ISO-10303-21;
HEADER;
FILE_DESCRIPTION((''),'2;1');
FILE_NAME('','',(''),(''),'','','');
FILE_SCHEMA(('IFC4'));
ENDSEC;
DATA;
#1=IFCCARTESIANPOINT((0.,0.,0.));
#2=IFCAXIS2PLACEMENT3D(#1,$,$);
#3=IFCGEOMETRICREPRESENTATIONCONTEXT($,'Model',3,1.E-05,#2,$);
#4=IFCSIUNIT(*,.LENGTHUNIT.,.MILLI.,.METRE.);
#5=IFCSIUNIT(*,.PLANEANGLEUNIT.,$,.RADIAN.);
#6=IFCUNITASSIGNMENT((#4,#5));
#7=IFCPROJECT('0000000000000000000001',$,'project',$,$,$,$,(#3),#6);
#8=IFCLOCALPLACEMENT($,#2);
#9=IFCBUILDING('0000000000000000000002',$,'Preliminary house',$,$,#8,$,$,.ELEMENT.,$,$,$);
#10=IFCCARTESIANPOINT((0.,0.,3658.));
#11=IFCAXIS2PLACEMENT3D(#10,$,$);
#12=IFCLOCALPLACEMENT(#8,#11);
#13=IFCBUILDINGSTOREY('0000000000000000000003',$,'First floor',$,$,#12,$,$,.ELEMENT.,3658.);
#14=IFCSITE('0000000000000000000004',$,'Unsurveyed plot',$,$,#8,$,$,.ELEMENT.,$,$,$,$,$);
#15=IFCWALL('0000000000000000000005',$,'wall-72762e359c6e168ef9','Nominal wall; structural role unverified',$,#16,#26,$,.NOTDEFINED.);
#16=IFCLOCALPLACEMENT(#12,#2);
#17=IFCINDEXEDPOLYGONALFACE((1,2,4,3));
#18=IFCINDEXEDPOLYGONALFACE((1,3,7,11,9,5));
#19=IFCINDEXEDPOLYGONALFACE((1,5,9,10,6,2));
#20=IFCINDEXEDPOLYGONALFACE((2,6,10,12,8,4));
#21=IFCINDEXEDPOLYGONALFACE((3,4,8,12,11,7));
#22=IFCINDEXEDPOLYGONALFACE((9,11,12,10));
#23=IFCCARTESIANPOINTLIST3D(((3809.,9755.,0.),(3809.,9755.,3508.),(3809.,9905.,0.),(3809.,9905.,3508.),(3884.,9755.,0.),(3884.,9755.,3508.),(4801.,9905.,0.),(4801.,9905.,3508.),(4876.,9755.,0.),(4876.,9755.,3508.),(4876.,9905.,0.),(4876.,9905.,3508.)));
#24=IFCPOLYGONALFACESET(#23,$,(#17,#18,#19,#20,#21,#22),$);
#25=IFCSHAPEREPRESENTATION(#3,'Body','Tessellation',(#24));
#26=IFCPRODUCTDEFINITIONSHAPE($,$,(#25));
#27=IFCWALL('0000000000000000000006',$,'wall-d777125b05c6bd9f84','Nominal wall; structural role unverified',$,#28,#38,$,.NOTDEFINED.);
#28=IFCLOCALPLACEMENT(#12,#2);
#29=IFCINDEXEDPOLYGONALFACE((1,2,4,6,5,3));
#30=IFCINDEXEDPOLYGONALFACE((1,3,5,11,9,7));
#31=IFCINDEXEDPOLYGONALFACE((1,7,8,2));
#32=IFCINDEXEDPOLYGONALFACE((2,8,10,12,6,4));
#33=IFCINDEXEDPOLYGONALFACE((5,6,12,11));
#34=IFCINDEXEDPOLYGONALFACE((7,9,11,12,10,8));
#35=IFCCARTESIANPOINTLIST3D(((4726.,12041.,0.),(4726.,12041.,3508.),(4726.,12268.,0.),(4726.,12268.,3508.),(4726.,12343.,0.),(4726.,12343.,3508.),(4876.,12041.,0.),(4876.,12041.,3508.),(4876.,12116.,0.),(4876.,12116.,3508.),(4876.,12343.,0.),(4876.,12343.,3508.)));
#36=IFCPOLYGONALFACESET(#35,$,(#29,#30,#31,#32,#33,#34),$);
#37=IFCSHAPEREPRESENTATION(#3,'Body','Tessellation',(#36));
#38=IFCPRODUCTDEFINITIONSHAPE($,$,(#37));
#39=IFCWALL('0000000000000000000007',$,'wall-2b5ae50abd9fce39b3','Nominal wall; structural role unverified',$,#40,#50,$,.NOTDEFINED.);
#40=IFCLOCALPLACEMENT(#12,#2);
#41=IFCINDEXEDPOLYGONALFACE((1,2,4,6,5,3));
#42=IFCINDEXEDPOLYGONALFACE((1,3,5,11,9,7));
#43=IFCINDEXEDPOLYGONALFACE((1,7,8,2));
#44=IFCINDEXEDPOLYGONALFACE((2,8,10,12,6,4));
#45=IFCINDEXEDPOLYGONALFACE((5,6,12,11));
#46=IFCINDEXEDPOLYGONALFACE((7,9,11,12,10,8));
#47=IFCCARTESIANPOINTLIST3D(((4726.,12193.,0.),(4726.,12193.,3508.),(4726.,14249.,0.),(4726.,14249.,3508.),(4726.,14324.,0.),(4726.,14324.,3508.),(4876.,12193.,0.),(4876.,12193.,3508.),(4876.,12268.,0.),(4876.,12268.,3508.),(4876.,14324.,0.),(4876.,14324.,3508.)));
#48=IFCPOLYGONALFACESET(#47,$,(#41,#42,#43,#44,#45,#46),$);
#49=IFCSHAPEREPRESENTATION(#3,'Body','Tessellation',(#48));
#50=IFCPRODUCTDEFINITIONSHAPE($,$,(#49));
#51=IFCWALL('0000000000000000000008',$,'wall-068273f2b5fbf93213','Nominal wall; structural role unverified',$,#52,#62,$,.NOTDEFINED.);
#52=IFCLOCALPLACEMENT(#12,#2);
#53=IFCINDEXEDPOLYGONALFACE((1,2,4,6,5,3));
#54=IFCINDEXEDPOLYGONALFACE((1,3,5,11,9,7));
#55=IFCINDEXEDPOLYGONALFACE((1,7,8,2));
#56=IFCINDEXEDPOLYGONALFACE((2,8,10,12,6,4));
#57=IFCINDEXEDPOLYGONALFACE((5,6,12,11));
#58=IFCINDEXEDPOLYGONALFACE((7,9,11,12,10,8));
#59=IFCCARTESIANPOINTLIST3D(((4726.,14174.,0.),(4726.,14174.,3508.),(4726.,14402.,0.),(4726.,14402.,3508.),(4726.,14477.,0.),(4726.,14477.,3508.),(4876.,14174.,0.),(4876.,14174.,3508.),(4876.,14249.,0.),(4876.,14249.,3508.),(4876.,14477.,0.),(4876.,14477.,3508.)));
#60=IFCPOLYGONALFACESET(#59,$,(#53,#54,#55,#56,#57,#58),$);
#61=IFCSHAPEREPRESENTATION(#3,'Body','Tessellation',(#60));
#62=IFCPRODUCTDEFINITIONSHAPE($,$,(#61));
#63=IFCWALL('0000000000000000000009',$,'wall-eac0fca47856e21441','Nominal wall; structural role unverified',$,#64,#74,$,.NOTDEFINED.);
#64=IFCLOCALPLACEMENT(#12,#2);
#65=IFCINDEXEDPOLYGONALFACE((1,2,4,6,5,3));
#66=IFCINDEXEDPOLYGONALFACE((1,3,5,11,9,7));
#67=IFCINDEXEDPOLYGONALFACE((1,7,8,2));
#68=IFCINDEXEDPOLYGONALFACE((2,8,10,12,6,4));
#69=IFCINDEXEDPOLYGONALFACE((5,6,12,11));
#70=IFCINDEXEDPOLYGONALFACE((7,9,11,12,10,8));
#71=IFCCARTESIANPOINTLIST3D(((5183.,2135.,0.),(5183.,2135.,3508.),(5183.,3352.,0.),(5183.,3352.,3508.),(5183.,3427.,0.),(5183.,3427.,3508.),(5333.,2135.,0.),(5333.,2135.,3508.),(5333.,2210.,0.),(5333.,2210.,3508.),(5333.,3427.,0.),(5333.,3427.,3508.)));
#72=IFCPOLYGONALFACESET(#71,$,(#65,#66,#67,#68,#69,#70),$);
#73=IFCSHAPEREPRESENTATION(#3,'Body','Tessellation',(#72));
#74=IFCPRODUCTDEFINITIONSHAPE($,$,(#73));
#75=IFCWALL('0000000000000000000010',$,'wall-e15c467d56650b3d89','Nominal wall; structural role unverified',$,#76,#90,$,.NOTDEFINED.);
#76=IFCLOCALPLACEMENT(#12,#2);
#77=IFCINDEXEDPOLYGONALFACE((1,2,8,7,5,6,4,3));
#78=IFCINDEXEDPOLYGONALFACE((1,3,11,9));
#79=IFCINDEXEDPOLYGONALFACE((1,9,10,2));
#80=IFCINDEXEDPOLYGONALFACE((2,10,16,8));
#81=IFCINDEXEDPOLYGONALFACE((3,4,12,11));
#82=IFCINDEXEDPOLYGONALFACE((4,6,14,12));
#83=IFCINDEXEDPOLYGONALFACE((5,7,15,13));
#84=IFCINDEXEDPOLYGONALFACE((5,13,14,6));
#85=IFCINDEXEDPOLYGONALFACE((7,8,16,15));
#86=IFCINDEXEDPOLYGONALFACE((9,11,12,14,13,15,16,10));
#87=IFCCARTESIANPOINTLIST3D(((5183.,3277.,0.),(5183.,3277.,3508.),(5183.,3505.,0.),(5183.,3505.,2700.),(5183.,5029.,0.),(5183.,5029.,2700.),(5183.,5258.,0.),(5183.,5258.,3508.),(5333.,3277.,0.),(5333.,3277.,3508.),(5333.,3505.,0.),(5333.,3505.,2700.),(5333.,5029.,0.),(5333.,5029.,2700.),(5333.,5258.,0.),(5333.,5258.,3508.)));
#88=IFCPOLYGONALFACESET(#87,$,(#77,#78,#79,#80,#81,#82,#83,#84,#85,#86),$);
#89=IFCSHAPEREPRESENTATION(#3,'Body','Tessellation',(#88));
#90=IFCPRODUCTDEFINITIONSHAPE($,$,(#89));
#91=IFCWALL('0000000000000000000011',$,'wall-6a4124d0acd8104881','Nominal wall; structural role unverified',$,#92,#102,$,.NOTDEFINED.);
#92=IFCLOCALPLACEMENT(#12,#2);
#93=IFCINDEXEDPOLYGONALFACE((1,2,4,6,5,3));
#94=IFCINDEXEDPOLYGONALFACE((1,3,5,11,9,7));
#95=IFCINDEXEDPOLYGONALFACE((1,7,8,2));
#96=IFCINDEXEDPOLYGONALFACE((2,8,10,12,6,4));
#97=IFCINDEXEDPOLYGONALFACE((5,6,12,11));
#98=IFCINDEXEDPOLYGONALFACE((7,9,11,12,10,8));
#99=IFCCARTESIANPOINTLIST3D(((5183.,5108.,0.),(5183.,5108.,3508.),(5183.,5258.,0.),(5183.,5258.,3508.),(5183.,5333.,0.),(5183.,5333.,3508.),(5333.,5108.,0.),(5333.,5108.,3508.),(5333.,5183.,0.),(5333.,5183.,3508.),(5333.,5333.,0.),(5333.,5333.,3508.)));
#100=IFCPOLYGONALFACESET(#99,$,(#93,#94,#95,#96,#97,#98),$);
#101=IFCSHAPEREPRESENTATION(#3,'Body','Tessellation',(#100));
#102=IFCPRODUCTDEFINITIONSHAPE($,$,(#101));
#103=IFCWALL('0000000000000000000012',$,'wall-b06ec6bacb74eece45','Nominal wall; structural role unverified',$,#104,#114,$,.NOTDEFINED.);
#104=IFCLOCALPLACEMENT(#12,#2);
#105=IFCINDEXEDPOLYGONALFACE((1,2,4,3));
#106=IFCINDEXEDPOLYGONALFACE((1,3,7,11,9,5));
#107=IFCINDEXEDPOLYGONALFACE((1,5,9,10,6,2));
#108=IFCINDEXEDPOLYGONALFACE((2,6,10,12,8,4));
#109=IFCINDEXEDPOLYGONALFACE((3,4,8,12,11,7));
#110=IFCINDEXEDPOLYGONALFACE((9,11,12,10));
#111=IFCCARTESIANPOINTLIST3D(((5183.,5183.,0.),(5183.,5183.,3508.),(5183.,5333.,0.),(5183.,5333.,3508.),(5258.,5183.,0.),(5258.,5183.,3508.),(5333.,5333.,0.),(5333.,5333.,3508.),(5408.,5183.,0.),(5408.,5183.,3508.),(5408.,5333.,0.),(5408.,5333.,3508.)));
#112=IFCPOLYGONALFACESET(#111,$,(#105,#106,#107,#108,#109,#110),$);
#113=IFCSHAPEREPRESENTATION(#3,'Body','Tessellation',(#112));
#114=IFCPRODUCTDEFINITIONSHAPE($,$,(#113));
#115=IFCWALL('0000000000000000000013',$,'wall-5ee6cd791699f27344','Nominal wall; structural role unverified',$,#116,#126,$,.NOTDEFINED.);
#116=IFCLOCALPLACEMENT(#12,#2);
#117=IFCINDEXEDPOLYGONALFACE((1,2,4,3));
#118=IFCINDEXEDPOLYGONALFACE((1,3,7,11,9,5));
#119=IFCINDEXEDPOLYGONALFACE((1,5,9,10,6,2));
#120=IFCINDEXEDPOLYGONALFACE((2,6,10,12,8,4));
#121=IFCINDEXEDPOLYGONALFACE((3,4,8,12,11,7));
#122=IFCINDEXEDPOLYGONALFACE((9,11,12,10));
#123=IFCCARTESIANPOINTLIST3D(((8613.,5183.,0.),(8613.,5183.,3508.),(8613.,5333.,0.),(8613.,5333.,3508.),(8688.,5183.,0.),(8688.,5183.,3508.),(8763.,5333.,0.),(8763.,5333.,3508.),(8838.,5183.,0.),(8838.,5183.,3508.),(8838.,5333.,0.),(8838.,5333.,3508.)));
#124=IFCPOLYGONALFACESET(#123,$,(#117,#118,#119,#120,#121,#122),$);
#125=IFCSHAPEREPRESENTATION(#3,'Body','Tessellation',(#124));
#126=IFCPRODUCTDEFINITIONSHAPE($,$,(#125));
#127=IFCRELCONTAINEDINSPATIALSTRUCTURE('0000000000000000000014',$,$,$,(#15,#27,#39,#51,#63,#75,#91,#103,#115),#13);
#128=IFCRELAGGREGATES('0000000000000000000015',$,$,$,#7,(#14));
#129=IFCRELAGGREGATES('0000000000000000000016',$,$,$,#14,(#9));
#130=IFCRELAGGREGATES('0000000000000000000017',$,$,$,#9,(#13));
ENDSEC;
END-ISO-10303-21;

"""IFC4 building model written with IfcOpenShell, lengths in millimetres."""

from ifc_helpers import new_model, si_unit, frame, origin, place, context, project, spatial, polyline, outline, extrude, element, save


model = new_model("IFC4")

# Units and contexts
model_context = context("Model", 3, precision=1e-05, world=origin())
ifc_project = project(units=[si_unit("LENGTHUNIT", "METRE", prefix="MILLI"), si_unit("PLANEANGLEUNIT", "RADIAN")], contexts=[model_context])

# Site, building, storey
placement_1 = place(None, origin())
site = spatial("IfcSite", under=ifc_project, at=placement_1, Name="Unsurveyed plot", CompositionType="ELEMENT")
building = spatial("IfcBuilding", under=site, at=placement_1, Name="Preliminary house", CompositionType="ELEMENT")
placement_2 = place(placement_1, frame((0.0, 0.0, 3658.0)))
storey = spatial("IfcBuildingStorey", under=building, at=placement_2, Name="First floor", CompositionType="ELEMENT", Elevation=3658.0)

# Wall
element("IfcWall", 1, at=placement_2, inside=storey, Name="wall-72762e359c6e168ef9", Description="Nominal wall; structural role unverified", PredefinedType="NOTDEFINED", context=model_context, shape_type="SweptSolid", body=[
    extrude(outline(polyline([(4801.0, 9905.0), (4876.0, 9905.0), (4876.0, 9755.0), (3884.0, 9755.0), (3809.0, 9755.0), (3809.0, 9905.0), (4801.0, 9905.0)])), origin(), (0.0, 0.0, 1.0), 3508.0),
])

# Walls
element("IfcWall", 2, at=placement_2, inside=storey, Name="wall-d777125b05c6bd9f84", Description="Nominal wall; structural role unverified", PredefinedType="NOTDEFINED", context=model_context, shape_type="SweptSolid", body=[
    extrude(outline(polyline([(4726.0, 12268.0), (4726.0, 12343.0), (4876.0, 12343.0), (4876.0, 12116.0), (4876.0, 12041.0), (4726.0, 12041.0), (4726.0, 12268.0)])), origin(), (0.0, 0.0, 1.0), 3508.0),
])
element("IfcWall", 3, at=placement_2, inside=storey, Name="wall-2b5ae50abd9fce39b3", Description="Nominal wall; structural role unverified", PredefinedType="NOTDEFINED", context=model_context, shape_type="SweptSolid", body=[
    extrude(outline(polyline([(4726.0, 14249.0), (4726.0, 14324.0), (4876.0, 14324.0), (4876.0, 12268.0), (4876.0, 12193.0), (4726.0, 12193.0), (4726.0, 14249.0)])), origin(), (0.0, 0.0, 1.0), 3508.0),
])

# Wall
element("IfcWall", 4, at=placement_2, inside=storey, Name="wall-068273f2b5fbf93213", Description="Nominal wall; structural role unverified", PredefinedType="NOTDEFINED", context=model_context, shape_type="SweptSolid", body=[
    extrude(outline(polyline([(4726.0, 14402.0), (4726.0, 14477.0), (4876.0, 14477.0), (4876.0, 14249.0), (4876.0, 14174.0), (4726.0, 14174.0), (4726.0, 14402.0)])), origin(), (0.0, 0.0, 1.0), 3508.0),
])

# Wall
element("IfcWall", 5, at=placement_2, inside=storey, Name="wall-eac0fca47856e21441", Description="Nominal wall; structural role unverified", PredefinedType="NOTDEFINED", context=model_context, shape_type="SweptSolid", body=[
    extrude(outline(polyline([(5183.0, 3352.0), (5183.0, 3427.0), (5333.0, 3427.0), (5333.0, 2210.0), (5333.0, 2135.0), (5183.0, 2135.0), (5183.0, 3352.0)])), origin(), (0.0, 0.0, 1.0), 3508.0),
])

# Wall, opening
wall_1 = element("IfcWall", 6, at=placement_2, inside=storey, Name="wall-e15c467d56650b3d89", Description="Nominal wall; structural role unverified", PredefinedType="NOTDEFINED", context=model_context, shape_type="SweptSolid", body=[
    extrude(outline(polyline([(5183.0, 5183.0), (5183.0, 5258.0), (5333.0, 5258.0), (5333.0, 3352.0), (5333.0, 3277.0), (5183.0, 3277.0), (5183.0, 5183.0)])), origin(), (0.0, 0.0, 1.0), 3508.0),
])
element("IfcOpeningElement", 7, at=placement_2, cuts=wall_1, PredefinedType="OPENING", context=model_context, shape_type="SweptSolid", body=[
    extrude(outline(polyline([(5708.0, 3505.0), (5708.0, 5029.0), (4808.0, 5029.0), (4808.0, 3505.0), (5708.0, 3505.0)])), origin(), (0.0, 0.0, 1.0), 2700.0),
])

# Wall
element("IfcWall", 8, at=placement_2, inside=storey, Name="wall-6a4124d0acd8104881", Description="Nominal wall; structural role unverified", PredefinedType="NOTDEFINED", context=model_context, shape_type="SweptSolid", body=[
    extrude(outline(polyline([(5183.0, 5258.0), (5183.0, 5333.0), (5333.0, 5333.0), (5333.0, 5183.0), (5333.0, 5108.0), (5183.0, 5108.0), (5183.0, 5258.0)])), origin(), (0.0, 0.0, 1.0), 3508.0),
])

# Wall
element("IfcWall", 9, at=placement_2, inside=storey, Name="wall-b06ec6bacb74eece45", Description="Nominal wall; structural role unverified", PredefinedType="NOTDEFINED", context=model_context, shape_type="SweptSolid", body=[
    extrude(outline(polyline([(5333.0, 5333.0), (5408.0, 5333.0), (5408.0, 5183.0), (5258.0, 5183.0), (5183.0, 5183.0), (5183.0, 5333.0), (5333.0, 5333.0)])), origin(), (0.0, 0.0, 1.0), 3508.0),
])

# Wall
element("IfcWall", 10, at=placement_2, inside=storey, Name="wall-5ee6cd791699f27344", Description="Nominal wall; structural role unverified", PredefinedType="NOTDEFINED", context=model_context, shape_type="SweptSolid", body=[
    extrude(outline(polyline([(8763.0, 5333.0), (8838.0, 5333.0), (8838.0, 5183.0), (8688.0, 5183.0), (8613.0, 5183.0), (8613.0, 5333.0), (8763.0, 5333.0)])), origin(), (0.0, 0.0, 1.0), 3508.0),
])

save(model, "model.ifc")
